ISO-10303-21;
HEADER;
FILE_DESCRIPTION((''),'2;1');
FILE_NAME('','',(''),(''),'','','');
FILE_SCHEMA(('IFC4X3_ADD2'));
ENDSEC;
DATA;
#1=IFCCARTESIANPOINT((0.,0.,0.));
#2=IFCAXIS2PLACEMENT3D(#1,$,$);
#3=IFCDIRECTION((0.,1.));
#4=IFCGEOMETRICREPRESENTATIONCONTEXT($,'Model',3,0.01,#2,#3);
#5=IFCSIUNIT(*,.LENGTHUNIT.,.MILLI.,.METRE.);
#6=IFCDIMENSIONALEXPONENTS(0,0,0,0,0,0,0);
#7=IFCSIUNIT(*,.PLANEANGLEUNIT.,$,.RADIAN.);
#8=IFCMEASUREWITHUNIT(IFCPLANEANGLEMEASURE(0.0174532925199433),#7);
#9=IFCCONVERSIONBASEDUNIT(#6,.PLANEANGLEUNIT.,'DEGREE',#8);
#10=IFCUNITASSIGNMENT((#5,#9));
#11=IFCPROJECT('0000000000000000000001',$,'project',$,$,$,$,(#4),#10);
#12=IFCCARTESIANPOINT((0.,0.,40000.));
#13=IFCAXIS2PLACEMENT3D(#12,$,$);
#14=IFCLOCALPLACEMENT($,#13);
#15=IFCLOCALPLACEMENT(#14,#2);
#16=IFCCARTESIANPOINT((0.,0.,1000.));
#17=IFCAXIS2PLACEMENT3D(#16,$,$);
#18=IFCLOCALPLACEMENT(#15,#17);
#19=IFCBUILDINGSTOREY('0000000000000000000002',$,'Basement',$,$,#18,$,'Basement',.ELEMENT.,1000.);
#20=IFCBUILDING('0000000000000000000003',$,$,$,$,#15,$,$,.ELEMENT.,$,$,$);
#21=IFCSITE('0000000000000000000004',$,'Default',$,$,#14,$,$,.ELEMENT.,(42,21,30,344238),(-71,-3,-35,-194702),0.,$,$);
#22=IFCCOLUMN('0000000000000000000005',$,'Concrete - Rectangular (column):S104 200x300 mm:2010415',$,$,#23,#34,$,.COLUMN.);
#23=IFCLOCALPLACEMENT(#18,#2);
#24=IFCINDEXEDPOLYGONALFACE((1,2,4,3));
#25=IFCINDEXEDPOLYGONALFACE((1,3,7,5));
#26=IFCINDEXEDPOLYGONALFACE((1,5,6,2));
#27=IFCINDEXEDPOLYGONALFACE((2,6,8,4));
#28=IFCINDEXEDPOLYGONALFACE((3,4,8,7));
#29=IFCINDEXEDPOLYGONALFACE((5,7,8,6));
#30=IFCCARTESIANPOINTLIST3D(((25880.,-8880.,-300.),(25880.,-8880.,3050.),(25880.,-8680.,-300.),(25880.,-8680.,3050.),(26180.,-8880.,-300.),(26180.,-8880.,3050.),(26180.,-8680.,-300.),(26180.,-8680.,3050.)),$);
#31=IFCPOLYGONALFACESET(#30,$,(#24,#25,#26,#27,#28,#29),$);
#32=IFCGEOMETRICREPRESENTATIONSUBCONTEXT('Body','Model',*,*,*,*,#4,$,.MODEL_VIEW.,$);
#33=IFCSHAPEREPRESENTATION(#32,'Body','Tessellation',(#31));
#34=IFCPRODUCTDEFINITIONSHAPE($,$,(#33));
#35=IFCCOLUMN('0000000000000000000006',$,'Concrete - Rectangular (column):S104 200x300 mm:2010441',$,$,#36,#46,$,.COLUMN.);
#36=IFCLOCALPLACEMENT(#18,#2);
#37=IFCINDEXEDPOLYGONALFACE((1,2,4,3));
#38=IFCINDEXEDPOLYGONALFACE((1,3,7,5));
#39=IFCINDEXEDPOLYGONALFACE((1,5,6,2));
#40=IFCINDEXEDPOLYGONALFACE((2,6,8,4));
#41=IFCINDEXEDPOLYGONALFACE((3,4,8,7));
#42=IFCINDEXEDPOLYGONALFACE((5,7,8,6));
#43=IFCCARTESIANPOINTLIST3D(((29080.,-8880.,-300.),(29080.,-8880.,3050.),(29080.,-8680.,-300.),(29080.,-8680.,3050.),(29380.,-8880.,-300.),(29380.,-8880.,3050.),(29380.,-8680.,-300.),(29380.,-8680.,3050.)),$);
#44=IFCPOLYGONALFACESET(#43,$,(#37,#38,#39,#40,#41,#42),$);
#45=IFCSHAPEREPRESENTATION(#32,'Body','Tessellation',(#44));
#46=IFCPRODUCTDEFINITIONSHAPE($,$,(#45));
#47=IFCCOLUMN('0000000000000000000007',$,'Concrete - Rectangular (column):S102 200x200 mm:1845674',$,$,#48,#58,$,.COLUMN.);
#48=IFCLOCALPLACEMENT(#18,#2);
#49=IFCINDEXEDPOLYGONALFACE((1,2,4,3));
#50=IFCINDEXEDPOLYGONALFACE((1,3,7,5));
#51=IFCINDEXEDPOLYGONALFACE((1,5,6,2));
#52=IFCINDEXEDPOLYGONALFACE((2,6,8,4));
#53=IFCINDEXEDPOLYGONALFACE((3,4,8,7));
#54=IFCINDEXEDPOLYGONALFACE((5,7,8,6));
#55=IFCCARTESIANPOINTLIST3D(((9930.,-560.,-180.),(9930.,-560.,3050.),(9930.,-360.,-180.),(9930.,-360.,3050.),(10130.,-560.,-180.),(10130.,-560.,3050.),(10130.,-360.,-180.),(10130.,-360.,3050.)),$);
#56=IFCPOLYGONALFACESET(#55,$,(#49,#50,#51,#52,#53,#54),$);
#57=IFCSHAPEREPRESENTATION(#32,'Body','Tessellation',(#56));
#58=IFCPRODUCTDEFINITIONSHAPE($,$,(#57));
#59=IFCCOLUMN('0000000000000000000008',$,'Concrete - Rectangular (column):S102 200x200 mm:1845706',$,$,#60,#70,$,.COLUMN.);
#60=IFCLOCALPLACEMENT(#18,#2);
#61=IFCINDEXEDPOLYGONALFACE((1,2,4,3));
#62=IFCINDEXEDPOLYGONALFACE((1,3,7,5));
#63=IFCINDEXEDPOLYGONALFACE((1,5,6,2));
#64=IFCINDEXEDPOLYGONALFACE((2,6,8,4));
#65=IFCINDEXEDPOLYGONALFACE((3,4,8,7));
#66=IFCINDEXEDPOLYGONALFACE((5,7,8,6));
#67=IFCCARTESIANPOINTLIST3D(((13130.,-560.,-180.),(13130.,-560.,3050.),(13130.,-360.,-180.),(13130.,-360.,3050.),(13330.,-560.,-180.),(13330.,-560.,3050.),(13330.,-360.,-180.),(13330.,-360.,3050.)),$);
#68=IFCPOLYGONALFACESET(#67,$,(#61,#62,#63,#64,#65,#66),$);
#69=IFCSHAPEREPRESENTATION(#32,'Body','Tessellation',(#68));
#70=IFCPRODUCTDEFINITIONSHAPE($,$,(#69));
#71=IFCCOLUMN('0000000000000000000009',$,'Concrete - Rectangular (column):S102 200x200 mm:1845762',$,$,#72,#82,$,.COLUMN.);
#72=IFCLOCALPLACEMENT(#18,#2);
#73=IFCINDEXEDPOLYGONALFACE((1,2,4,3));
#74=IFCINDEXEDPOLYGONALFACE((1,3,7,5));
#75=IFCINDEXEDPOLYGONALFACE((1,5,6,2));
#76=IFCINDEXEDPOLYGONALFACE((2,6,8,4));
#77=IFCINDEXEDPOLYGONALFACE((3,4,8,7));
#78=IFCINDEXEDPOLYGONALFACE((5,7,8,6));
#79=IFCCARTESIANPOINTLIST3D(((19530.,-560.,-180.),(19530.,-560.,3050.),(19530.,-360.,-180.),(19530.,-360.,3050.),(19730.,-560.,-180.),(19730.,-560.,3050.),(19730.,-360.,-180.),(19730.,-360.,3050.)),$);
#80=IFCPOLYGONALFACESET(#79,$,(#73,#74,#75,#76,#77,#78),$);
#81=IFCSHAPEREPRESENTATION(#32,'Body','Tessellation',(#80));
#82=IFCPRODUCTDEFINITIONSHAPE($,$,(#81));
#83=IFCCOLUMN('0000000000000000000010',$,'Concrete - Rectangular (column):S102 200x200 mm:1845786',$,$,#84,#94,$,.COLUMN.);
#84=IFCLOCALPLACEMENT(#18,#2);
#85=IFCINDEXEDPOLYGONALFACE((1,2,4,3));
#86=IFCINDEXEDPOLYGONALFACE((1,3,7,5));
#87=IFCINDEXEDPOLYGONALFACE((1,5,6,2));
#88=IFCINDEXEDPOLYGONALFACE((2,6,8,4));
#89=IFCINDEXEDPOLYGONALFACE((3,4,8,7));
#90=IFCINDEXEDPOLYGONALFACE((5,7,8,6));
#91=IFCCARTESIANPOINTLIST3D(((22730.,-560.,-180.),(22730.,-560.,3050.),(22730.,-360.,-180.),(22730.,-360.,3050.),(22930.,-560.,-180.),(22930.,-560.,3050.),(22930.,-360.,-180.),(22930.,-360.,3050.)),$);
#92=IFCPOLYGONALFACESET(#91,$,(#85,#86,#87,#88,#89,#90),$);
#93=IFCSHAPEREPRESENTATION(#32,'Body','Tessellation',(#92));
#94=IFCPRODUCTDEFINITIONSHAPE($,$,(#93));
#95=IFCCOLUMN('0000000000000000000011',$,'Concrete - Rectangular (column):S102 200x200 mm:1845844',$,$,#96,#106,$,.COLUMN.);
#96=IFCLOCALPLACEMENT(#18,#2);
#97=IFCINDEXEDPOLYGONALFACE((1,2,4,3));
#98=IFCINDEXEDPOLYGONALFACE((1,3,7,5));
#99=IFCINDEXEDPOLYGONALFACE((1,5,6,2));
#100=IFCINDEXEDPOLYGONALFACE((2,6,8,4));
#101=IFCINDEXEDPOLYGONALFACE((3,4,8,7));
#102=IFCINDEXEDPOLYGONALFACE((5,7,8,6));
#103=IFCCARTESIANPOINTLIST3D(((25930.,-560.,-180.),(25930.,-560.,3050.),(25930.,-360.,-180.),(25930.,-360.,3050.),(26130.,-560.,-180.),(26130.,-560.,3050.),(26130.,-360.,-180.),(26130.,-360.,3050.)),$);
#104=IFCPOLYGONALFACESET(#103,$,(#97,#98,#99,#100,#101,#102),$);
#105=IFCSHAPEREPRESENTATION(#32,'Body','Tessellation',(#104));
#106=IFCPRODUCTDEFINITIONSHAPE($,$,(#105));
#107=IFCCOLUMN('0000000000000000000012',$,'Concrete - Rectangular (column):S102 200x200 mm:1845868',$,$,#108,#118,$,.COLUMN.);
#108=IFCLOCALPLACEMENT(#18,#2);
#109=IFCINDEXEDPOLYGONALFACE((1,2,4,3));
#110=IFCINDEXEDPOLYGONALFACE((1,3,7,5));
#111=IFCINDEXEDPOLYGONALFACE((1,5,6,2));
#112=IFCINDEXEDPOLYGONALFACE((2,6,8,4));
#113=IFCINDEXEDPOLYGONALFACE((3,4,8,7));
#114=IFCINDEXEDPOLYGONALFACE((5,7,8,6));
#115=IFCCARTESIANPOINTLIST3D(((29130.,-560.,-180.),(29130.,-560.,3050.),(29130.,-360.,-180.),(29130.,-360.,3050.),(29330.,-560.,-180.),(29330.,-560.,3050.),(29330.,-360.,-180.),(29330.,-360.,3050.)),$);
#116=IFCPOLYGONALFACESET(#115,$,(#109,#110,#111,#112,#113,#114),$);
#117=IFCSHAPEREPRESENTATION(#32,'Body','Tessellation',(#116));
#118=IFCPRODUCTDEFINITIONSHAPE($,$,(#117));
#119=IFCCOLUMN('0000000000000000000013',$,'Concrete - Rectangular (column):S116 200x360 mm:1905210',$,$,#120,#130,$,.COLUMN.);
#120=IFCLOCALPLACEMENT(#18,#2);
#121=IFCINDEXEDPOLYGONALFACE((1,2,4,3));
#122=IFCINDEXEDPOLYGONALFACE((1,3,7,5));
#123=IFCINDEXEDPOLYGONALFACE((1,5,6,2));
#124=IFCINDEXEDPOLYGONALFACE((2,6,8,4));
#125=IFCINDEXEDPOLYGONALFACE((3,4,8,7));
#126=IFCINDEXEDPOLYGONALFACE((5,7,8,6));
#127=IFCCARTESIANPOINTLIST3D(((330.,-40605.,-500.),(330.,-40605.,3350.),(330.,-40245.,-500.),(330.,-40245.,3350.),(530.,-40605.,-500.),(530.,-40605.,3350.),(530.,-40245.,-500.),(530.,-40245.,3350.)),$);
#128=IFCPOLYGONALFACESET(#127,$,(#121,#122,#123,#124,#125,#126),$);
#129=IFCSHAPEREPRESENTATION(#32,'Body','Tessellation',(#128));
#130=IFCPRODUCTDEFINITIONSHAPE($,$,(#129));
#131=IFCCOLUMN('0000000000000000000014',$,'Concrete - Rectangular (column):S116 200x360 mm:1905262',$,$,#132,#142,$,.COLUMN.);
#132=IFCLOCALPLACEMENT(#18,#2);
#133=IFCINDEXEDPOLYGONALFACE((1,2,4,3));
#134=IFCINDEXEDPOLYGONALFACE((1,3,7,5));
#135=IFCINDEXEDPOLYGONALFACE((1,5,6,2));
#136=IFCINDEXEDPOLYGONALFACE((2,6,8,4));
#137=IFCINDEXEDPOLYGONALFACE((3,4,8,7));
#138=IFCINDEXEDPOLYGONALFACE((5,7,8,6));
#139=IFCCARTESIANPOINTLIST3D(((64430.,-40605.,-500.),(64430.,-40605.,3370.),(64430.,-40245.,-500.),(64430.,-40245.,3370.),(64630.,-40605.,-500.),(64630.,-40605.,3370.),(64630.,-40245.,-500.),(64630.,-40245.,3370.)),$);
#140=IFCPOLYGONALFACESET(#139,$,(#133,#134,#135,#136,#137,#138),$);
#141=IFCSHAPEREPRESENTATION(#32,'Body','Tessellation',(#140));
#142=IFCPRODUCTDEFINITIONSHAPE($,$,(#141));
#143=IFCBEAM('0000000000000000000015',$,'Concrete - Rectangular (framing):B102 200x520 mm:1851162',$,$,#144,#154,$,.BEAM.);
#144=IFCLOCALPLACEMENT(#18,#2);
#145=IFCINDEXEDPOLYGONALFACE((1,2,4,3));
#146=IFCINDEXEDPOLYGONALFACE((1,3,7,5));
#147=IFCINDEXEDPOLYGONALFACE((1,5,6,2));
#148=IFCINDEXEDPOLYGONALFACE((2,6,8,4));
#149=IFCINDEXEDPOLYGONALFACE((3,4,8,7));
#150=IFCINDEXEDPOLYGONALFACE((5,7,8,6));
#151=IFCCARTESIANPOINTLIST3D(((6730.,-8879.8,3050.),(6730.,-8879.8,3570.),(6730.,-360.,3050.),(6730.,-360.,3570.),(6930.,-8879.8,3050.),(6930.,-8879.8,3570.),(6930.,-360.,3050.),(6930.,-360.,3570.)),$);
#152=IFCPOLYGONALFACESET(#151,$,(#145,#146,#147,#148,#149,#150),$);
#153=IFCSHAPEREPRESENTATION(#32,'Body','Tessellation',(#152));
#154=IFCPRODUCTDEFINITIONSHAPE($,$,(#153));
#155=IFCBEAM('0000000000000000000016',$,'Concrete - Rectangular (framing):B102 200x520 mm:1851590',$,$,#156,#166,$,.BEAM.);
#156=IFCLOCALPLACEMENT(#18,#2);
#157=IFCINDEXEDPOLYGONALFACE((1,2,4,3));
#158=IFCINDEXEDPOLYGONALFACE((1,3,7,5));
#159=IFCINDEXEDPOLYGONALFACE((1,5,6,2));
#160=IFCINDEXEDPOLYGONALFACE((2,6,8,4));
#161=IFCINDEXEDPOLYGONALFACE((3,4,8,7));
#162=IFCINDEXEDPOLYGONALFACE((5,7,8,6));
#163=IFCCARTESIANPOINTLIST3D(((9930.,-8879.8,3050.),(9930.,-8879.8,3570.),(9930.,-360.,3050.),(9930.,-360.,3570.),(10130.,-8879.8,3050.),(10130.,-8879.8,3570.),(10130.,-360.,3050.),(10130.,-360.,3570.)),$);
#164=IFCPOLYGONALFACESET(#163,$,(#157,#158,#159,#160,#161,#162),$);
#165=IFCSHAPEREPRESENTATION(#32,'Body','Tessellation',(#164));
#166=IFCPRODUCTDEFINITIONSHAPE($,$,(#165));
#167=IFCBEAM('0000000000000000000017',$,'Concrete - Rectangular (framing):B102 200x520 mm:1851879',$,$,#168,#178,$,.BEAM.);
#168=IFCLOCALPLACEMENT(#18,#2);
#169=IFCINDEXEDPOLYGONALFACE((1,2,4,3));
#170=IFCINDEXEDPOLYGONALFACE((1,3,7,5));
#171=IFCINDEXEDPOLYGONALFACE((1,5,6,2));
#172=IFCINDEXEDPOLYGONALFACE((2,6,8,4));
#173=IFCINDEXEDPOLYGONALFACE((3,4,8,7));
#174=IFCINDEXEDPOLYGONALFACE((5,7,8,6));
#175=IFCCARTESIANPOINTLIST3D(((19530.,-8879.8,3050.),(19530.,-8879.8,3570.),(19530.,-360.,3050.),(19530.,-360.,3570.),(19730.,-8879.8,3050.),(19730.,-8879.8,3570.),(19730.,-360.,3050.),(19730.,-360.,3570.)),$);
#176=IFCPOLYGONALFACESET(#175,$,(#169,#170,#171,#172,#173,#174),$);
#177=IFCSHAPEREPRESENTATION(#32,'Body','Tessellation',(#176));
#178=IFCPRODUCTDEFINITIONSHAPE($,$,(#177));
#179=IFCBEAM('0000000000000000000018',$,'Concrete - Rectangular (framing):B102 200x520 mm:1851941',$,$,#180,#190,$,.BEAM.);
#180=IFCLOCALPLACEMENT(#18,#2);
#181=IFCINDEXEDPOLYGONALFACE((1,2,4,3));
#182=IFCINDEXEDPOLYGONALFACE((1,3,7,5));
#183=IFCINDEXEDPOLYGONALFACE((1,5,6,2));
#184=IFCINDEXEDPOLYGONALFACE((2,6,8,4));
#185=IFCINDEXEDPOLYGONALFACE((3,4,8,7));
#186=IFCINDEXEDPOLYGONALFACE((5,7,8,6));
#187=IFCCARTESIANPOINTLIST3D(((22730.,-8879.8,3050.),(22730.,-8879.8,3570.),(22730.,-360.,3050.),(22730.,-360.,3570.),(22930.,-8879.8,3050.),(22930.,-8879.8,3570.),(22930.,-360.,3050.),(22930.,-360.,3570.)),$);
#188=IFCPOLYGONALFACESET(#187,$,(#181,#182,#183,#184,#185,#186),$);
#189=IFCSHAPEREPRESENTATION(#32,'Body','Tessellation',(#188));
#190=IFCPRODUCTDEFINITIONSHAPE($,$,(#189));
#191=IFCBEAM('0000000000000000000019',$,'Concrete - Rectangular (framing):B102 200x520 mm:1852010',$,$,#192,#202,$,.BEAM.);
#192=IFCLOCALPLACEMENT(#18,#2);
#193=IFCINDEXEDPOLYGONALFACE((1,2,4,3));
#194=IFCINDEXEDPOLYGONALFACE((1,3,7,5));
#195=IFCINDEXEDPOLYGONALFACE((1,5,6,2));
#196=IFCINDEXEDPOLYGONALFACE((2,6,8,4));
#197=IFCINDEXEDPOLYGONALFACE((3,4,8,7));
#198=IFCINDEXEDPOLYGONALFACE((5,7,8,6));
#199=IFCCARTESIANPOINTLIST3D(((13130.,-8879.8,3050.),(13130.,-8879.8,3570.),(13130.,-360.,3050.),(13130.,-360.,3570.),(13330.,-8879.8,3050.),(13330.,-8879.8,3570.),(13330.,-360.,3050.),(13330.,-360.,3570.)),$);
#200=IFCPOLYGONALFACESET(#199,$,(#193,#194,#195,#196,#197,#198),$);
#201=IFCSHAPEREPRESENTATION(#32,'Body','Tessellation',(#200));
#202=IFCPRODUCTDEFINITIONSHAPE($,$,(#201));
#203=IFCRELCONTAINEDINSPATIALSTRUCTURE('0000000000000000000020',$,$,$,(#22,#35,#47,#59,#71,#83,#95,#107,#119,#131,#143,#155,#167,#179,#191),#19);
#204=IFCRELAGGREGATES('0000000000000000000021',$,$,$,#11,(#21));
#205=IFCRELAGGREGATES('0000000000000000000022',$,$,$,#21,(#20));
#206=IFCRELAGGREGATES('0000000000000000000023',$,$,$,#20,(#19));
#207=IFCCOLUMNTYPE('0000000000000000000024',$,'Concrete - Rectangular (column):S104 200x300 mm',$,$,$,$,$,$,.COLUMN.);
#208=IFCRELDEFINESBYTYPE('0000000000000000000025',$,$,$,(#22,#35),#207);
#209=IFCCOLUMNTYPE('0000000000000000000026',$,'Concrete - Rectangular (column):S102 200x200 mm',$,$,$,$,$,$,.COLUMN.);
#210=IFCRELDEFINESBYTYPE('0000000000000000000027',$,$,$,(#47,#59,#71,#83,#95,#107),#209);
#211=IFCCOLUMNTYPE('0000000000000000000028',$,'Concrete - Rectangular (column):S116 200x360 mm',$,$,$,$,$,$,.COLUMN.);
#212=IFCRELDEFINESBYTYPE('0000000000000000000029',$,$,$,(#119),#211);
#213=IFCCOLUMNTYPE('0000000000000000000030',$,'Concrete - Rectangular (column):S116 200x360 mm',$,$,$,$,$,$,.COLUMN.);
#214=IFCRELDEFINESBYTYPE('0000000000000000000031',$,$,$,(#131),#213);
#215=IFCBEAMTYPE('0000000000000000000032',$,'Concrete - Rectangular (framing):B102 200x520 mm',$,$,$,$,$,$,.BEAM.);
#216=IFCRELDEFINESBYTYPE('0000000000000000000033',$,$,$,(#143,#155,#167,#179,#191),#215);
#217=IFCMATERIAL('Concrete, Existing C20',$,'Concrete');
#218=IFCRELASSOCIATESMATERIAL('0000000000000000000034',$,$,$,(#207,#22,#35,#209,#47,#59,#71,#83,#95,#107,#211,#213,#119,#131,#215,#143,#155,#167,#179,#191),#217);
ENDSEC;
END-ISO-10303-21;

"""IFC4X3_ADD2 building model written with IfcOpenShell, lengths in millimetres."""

from ifc_helpers import new_model, entity, si_unit, converted_unit, direction, frame, frame_2d, origin, origin_2d_with_axis, place, context, subcontext, project, spatial, rectangle, extrude, source, transform, mapped, material, material_profile, profile_set, profile_usage, type_object, type_shapes, element, save


model = new_model("IFC4X3_ADD2")

# Units and contexts
model_context = context("Model", 3, precision=0.01, world=origin(), true_north=direction((0.0, 1.0)))
body_context = subcontext(model_context, "Body", "Model", "MODEL_VIEW")
ifc_project = project(units=[si_unit("LENGTHUNIT", "METRE", prefix="MILLI"), converted_unit("PLANEANGLEUNIT", "DEGREE", entity("IfcPlaneAngleMeasure", 0.0174532925199433), si_unit("PLANEANGLEUNIT", "RADIAN"), dimensions=[0, 0, 0, 0, 0, 0, 0])], contexts=[model_context])

# Site, building, storey
site_placement = place(None, frame((0.0, 0.0, 40000.0)))
site = spatial("IfcSite", under=ifc_project, at=site_placement, Name="Default", CompositionType="ELEMENT", RefLatitude=(42, 21, 30, 344238), RefLongitude=(-71, -3, -35, -194702), RefElevation=0.0)
building_placement = place(site_placement, origin())
building = spatial("IfcBuilding", under=site, at=building_placement, CompositionType="ELEMENT")
storey_placement = place(building_placement, frame((0.0, 0.0, 1000.0)))
storey = spatial("IfcBuildingStorey", under=building, at=storey_placement, Name="Basement", LongName="Basement", CompositionType="ELEMENT", Elevation=1000.0)

# Columns
ifc_material_1 = material(Name="Concrete, Existing C20", Category="Concrete")
ifc_material_profile_1 = material_profile(ifc_material_1, rectangle(XDim=200.0, YDim=300.0, at=frame_2d((0.0, 0.0), x_axis=(1.0, 0.0))), Name="S104 200x300 mm")
ifc_profile_set_1 = profile_set([ifc_material_profile_1], Name="S104 200x300 mm")
ifc_profile_usage_1 = profile_usage(ifc_profile_set_1)
column_type_1 = type_object("IfcColumnType", Name="Concrete - Rectangular (column):S104 200x300 mm", PredefinedType="COLUMN", material=ifc_profile_set_1)
shared_shape_1 = source(origin(), body_context, "Body", "SweptSolid", [
    extrude(rectangle(XDim=200.0, YDim=300.0, at=origin_2d_with_axis()), frame((0.0, 0.0, 700.0), z_axis=(0.0, 0.0, 1.0), x_axis=(-1.0, 0.0, 0.0)), (0.0, 0.0, 1.0), 3350.0),
])
type_shapes(column_type_1, [shared_shape_1])
for number, where, z_axis, x_axis, name in (
    (1, (26030.0, -8780.0, -1000.0), (0.0, 0.0, 1.0), (0.0, -1.0, 0.0), "Concrete - Rectangular (column):S104 200x300 mm:2010415"),
    (2, (29230.0, -8780.0, -1000.0), (0.0, 0.0, 1.0), (0.0, -1.0, 0.0), "Concrete - Rectangular (column):S104 200x300 mm:2010441"),
):
    element("IfcColumn", number, at=place(storey_placement, frame(where, z_axis=z_axis, x_axis=x_axis)), inside=storey, type_object=column_type_1, material=ifc_profile_usage_1, Name=name, PredefinedType="COLUMN", context=body_context, shape_type="MappedRepresentation", body=[
        mapped(shared_shape_1, transform((0.0, 0.0, 0.0), scale=1.0)),
    ])
ifc_material_profile_2 = material_profile(ifc_material_1, rectangle(XDim=200.0, YDim=200.0, at=frame_2d((0.0, 0.0), x_axis=(1.0, 0.0))), Name="S102 200x200 mm")
ifc_profile_set_2 = profile_set([ifc_material_profile_2], Name="S102 200x200 mm")
ifc_profile_usage_2 = profile_usage(ifc_profile_set_2)
column_type_2 = type_object("IfcColumnType", Name="Concrete - Rectangular (column):S102 200x200 mm", PredefinedType="COLUMN", material=ifc_profile_set_2)
shared_shape_2 = source(origin(), body_context, "Body", "SweptSolid", [
    extrude(rectangle(XDim=200.0, YDim=200.0, at=origin_2d_with_axis()), frame((0.0, 0.0, 820.0), z_axis=(0.0, 0.0, 1.0), x_axis=(-1.0, 0.0, 0.0)), (0.0, 0.0, 1.0), 3230.0),
])
type_shapes(column_type_2, [shared_shape_2])
for number, where, z_axis, x_axis, name in (
    (3, (10030.0, -460.0, -1000.0), (0.0, 0.0, 1.0), (0.0, -1.0, 0.0), "Concrete - Rectangular (column):S102 200x200 mm:1845674"),
    (4, (13230.0, -460.0, -1000.0), (0.0, 0.0, 1.0), (0.0, -1.0, 0.0), "Concrete - Rectangular (column):S102 200x200 mm:1845706"),
    (5, (19630.0, -460.0, -1000.0), (0.0, 0.0, 1.0), (0.0, -1.0, 0.0), "Concrete - Rectangular (column):S102 200x200 mm:1845762"),
    (6, (22830.0, -460.0, -1000.0), (0.0, 0.0, 1.0), (0.0, -1.0, 0.0), "Concrete - Rectangular (column):S102 200x200 mm:1845786"),
    (7, (26030.0, -460.0, -1000.0), (0.0, 0.0, 1.0), (0.0, -1.0, 0.0), "Concrete - Rectangular (column):S102 200x200 mm:1845844"),
    (8, (29230.0, -460.0, -1000.0), (0.0, 0.0, 1.0), (0.0, -1.0, 0.0), "Concrete - Rectangular (column):S102 200x200 mm:1845868"),
):
    element("IfcColumn", number, at=place(storey_placement, frame(where, z_axis=z_axis, x_axis=x_axis)), inside=storey, type_object=column_type_2, material=ifc_profile_usage_2, Name=name, PredefinedType="COLUMN", context=body_context, shape_type="MappedRepresentation", body=[
        mapped(shared_shape_2, transform((0.0, 0.0, 0.0), scale=1.0)),
    ])
ifc_material_profile_3 = material_profile(ifc_material_1, rectangle(XDim=360.0, YDim=200.0, at=origin_2d_with_axis()), Name="S116 200x360 mm")
ifc_profile_set_3 = profile_set([ifc_material_profile_3], Name="S116 200x360 mm")
ifc_profile_usage_3 = profile_usage(ifc_profile_set_3)
column_type_3 = type_object("IfcColumnType", Name="Concrete - Rectangular (column):S116 200x360 mm", PredefinedType="COLUMN", material=ifc_profile_set_3)
shared_shape_3 = source(origin(), body_context, "Body", "SweptSolid", [
    extrude(rectangle(XDim=360.0, YDim=200.0, at=frame_2d((0.0, 0.0), x_axis=(1.0, 0.0))), frame((430.0, -40425.0, 500.0), z_axis=(0.0, 0.0, 1.0), x_axis=(0.0, -1.0, 0.0)), (0.0, 0.0, 1.0), 3850.0),
])
type_shapes(column_type_3, [shared_shape_3])
column_1_placement = place(storey_placement, frame((0.0, 0.0, -1000.0)))
element("IfcColumn", 9, at=column_1_placement, inside=storey, type_object=column_type_3, material=ifc_profile_usage_3, Name="Concrete - Rectangular (column):S116 200x360 mm:1905210", PredefinedType="COLUMN", context=body_context, shape_type="MappedRepresentation", body=[
    mapped(shared_shape_3, transform((0.0, 0.0, 0.0), scale=1.0)),
])
column_type_4 = type_object("IfcColumnType", Name="Concrete - Rectangular (column):S116 200x360 mm", PredefinedType="COLUMN", material=ifc_profile_set_3)
shared_shape_4 = source(origin(), body_context, "Body", "SweptSolid", [
    extrude(rectangle(XDim=360.0, YDim=200.0, at=frame_2d((0.0, 0.0), x_axis=(1.0, 0.0))), frame((64530.0, -40425.0, 500.0), z_axis=(0.0, 0.0, 1.0), x_axis=(0.0, 1.0, 0.0)), (0.0, 0.0, 1.0), 3870.0),
])
type_shapes(column_type_4, [shared_shape_4])
column_2_placement = place(storey_placement, frame((0.0, 0.0, -1000.0)))
element("IfcColumn", 10, at=column_2_placement, inside=storey, type_object=column_type_4, material=ifc_profile_usage_3, Name="Concrete - Rectangular (column):S116 200x360 mm:1905262", PredefinedType="COLUMN", context=body_context, shape_type="MappedRepresentation", body=[
    mapped(shared_shape_4, transform((0.0, 0.0, 0.0), scale=1.0)),
])

# Beams
ifc_material_profile_4 = material_profile(ifc_material_1, rectangle(XDim=8519.8, YDim=200.0, at=origin_2d_with_axis()), Name="B102 200x520 mm")
ifc_profile_set_4 = profile_set([ifc_material_profile_4], Name="B102 200x520 mm")
ifc_profile_usage_4 = profile_usage(ifc_profile_set_4, cardinal=8)
beam_type_1 = type_object("IfcBeamType", Name="Concrete - Rectangular (framing):B102 200x520 mm", PredefinedType="BEAM", material=ifc_profile_set_4)
shared_shape_5 = source(origin(), body_context, "Body", "SweptSolid", [
    extrude(rectangle(XDim=8519.8, YDim=200.0, at=origin_2d_with_axis()), frame((-0.1, 0.0, -260.0), z_axis=(0.0, 0.0, 1.0), x_axis=(-1.0, 0.0, 0.0)), (0.0, 0.0, 1.0), 520.0),
])
type_shapes(beam_type_1, [shared_shape_5])
for number, where, z_axis, x_axis, name in (
    (11, (6830.0, -4620.0, 3310.0), (0.0, 0.0, 1.0), (0.0, -1.0, 0.0), "Concrete - Rectangular (framing):B102 200x520 mm:1851162"),
    (12, (10030.0, -4620.0, 3310.0), (0.0, 0.0, 1.0), (0.0, -1.0, 0.0), "Concrete - Rectangular (framing):B102 200x520 mm:1851590"),
    (13, (19630.0, -4620.0, 3310.0), (0.0, 0.0, 1.0), (0.0, -1.0, 0.0), "Concrete - Rectangular (framing):B102 200x520 mm:1851879"),
    (14, (22830.0, -4620.0, 3310.0), (0.0, 0.0, 1.0), (0.0, -1.0, 0.0), "Concrete - Rectangular (framing):B102 200x520 mm:1851941"),
    (15, (13230.0, -4620.0, 3310.0), (0.0, 0.0, 1.0), (0.0, -1.0, 0.0), "Concrete - Rectangular (framing):B102 200x520 mm:1852010"),
):
    element("IfcBeam", number, at=place(storey_placement, frame(where, z_axis=z_axis, x_axis=x_axis)), inside=storey, type_object=beam_type_1, material=ifc_profile_usage_4, Name=name, PredefinedType="BEAM", context=body_context, shape_type="MappedRepresentation", body=[
        mapped(shared_shape_5, transform((0.0, 0.0, 0.0), scale=1.0)),
    ])

save(model, "model.ifc")
